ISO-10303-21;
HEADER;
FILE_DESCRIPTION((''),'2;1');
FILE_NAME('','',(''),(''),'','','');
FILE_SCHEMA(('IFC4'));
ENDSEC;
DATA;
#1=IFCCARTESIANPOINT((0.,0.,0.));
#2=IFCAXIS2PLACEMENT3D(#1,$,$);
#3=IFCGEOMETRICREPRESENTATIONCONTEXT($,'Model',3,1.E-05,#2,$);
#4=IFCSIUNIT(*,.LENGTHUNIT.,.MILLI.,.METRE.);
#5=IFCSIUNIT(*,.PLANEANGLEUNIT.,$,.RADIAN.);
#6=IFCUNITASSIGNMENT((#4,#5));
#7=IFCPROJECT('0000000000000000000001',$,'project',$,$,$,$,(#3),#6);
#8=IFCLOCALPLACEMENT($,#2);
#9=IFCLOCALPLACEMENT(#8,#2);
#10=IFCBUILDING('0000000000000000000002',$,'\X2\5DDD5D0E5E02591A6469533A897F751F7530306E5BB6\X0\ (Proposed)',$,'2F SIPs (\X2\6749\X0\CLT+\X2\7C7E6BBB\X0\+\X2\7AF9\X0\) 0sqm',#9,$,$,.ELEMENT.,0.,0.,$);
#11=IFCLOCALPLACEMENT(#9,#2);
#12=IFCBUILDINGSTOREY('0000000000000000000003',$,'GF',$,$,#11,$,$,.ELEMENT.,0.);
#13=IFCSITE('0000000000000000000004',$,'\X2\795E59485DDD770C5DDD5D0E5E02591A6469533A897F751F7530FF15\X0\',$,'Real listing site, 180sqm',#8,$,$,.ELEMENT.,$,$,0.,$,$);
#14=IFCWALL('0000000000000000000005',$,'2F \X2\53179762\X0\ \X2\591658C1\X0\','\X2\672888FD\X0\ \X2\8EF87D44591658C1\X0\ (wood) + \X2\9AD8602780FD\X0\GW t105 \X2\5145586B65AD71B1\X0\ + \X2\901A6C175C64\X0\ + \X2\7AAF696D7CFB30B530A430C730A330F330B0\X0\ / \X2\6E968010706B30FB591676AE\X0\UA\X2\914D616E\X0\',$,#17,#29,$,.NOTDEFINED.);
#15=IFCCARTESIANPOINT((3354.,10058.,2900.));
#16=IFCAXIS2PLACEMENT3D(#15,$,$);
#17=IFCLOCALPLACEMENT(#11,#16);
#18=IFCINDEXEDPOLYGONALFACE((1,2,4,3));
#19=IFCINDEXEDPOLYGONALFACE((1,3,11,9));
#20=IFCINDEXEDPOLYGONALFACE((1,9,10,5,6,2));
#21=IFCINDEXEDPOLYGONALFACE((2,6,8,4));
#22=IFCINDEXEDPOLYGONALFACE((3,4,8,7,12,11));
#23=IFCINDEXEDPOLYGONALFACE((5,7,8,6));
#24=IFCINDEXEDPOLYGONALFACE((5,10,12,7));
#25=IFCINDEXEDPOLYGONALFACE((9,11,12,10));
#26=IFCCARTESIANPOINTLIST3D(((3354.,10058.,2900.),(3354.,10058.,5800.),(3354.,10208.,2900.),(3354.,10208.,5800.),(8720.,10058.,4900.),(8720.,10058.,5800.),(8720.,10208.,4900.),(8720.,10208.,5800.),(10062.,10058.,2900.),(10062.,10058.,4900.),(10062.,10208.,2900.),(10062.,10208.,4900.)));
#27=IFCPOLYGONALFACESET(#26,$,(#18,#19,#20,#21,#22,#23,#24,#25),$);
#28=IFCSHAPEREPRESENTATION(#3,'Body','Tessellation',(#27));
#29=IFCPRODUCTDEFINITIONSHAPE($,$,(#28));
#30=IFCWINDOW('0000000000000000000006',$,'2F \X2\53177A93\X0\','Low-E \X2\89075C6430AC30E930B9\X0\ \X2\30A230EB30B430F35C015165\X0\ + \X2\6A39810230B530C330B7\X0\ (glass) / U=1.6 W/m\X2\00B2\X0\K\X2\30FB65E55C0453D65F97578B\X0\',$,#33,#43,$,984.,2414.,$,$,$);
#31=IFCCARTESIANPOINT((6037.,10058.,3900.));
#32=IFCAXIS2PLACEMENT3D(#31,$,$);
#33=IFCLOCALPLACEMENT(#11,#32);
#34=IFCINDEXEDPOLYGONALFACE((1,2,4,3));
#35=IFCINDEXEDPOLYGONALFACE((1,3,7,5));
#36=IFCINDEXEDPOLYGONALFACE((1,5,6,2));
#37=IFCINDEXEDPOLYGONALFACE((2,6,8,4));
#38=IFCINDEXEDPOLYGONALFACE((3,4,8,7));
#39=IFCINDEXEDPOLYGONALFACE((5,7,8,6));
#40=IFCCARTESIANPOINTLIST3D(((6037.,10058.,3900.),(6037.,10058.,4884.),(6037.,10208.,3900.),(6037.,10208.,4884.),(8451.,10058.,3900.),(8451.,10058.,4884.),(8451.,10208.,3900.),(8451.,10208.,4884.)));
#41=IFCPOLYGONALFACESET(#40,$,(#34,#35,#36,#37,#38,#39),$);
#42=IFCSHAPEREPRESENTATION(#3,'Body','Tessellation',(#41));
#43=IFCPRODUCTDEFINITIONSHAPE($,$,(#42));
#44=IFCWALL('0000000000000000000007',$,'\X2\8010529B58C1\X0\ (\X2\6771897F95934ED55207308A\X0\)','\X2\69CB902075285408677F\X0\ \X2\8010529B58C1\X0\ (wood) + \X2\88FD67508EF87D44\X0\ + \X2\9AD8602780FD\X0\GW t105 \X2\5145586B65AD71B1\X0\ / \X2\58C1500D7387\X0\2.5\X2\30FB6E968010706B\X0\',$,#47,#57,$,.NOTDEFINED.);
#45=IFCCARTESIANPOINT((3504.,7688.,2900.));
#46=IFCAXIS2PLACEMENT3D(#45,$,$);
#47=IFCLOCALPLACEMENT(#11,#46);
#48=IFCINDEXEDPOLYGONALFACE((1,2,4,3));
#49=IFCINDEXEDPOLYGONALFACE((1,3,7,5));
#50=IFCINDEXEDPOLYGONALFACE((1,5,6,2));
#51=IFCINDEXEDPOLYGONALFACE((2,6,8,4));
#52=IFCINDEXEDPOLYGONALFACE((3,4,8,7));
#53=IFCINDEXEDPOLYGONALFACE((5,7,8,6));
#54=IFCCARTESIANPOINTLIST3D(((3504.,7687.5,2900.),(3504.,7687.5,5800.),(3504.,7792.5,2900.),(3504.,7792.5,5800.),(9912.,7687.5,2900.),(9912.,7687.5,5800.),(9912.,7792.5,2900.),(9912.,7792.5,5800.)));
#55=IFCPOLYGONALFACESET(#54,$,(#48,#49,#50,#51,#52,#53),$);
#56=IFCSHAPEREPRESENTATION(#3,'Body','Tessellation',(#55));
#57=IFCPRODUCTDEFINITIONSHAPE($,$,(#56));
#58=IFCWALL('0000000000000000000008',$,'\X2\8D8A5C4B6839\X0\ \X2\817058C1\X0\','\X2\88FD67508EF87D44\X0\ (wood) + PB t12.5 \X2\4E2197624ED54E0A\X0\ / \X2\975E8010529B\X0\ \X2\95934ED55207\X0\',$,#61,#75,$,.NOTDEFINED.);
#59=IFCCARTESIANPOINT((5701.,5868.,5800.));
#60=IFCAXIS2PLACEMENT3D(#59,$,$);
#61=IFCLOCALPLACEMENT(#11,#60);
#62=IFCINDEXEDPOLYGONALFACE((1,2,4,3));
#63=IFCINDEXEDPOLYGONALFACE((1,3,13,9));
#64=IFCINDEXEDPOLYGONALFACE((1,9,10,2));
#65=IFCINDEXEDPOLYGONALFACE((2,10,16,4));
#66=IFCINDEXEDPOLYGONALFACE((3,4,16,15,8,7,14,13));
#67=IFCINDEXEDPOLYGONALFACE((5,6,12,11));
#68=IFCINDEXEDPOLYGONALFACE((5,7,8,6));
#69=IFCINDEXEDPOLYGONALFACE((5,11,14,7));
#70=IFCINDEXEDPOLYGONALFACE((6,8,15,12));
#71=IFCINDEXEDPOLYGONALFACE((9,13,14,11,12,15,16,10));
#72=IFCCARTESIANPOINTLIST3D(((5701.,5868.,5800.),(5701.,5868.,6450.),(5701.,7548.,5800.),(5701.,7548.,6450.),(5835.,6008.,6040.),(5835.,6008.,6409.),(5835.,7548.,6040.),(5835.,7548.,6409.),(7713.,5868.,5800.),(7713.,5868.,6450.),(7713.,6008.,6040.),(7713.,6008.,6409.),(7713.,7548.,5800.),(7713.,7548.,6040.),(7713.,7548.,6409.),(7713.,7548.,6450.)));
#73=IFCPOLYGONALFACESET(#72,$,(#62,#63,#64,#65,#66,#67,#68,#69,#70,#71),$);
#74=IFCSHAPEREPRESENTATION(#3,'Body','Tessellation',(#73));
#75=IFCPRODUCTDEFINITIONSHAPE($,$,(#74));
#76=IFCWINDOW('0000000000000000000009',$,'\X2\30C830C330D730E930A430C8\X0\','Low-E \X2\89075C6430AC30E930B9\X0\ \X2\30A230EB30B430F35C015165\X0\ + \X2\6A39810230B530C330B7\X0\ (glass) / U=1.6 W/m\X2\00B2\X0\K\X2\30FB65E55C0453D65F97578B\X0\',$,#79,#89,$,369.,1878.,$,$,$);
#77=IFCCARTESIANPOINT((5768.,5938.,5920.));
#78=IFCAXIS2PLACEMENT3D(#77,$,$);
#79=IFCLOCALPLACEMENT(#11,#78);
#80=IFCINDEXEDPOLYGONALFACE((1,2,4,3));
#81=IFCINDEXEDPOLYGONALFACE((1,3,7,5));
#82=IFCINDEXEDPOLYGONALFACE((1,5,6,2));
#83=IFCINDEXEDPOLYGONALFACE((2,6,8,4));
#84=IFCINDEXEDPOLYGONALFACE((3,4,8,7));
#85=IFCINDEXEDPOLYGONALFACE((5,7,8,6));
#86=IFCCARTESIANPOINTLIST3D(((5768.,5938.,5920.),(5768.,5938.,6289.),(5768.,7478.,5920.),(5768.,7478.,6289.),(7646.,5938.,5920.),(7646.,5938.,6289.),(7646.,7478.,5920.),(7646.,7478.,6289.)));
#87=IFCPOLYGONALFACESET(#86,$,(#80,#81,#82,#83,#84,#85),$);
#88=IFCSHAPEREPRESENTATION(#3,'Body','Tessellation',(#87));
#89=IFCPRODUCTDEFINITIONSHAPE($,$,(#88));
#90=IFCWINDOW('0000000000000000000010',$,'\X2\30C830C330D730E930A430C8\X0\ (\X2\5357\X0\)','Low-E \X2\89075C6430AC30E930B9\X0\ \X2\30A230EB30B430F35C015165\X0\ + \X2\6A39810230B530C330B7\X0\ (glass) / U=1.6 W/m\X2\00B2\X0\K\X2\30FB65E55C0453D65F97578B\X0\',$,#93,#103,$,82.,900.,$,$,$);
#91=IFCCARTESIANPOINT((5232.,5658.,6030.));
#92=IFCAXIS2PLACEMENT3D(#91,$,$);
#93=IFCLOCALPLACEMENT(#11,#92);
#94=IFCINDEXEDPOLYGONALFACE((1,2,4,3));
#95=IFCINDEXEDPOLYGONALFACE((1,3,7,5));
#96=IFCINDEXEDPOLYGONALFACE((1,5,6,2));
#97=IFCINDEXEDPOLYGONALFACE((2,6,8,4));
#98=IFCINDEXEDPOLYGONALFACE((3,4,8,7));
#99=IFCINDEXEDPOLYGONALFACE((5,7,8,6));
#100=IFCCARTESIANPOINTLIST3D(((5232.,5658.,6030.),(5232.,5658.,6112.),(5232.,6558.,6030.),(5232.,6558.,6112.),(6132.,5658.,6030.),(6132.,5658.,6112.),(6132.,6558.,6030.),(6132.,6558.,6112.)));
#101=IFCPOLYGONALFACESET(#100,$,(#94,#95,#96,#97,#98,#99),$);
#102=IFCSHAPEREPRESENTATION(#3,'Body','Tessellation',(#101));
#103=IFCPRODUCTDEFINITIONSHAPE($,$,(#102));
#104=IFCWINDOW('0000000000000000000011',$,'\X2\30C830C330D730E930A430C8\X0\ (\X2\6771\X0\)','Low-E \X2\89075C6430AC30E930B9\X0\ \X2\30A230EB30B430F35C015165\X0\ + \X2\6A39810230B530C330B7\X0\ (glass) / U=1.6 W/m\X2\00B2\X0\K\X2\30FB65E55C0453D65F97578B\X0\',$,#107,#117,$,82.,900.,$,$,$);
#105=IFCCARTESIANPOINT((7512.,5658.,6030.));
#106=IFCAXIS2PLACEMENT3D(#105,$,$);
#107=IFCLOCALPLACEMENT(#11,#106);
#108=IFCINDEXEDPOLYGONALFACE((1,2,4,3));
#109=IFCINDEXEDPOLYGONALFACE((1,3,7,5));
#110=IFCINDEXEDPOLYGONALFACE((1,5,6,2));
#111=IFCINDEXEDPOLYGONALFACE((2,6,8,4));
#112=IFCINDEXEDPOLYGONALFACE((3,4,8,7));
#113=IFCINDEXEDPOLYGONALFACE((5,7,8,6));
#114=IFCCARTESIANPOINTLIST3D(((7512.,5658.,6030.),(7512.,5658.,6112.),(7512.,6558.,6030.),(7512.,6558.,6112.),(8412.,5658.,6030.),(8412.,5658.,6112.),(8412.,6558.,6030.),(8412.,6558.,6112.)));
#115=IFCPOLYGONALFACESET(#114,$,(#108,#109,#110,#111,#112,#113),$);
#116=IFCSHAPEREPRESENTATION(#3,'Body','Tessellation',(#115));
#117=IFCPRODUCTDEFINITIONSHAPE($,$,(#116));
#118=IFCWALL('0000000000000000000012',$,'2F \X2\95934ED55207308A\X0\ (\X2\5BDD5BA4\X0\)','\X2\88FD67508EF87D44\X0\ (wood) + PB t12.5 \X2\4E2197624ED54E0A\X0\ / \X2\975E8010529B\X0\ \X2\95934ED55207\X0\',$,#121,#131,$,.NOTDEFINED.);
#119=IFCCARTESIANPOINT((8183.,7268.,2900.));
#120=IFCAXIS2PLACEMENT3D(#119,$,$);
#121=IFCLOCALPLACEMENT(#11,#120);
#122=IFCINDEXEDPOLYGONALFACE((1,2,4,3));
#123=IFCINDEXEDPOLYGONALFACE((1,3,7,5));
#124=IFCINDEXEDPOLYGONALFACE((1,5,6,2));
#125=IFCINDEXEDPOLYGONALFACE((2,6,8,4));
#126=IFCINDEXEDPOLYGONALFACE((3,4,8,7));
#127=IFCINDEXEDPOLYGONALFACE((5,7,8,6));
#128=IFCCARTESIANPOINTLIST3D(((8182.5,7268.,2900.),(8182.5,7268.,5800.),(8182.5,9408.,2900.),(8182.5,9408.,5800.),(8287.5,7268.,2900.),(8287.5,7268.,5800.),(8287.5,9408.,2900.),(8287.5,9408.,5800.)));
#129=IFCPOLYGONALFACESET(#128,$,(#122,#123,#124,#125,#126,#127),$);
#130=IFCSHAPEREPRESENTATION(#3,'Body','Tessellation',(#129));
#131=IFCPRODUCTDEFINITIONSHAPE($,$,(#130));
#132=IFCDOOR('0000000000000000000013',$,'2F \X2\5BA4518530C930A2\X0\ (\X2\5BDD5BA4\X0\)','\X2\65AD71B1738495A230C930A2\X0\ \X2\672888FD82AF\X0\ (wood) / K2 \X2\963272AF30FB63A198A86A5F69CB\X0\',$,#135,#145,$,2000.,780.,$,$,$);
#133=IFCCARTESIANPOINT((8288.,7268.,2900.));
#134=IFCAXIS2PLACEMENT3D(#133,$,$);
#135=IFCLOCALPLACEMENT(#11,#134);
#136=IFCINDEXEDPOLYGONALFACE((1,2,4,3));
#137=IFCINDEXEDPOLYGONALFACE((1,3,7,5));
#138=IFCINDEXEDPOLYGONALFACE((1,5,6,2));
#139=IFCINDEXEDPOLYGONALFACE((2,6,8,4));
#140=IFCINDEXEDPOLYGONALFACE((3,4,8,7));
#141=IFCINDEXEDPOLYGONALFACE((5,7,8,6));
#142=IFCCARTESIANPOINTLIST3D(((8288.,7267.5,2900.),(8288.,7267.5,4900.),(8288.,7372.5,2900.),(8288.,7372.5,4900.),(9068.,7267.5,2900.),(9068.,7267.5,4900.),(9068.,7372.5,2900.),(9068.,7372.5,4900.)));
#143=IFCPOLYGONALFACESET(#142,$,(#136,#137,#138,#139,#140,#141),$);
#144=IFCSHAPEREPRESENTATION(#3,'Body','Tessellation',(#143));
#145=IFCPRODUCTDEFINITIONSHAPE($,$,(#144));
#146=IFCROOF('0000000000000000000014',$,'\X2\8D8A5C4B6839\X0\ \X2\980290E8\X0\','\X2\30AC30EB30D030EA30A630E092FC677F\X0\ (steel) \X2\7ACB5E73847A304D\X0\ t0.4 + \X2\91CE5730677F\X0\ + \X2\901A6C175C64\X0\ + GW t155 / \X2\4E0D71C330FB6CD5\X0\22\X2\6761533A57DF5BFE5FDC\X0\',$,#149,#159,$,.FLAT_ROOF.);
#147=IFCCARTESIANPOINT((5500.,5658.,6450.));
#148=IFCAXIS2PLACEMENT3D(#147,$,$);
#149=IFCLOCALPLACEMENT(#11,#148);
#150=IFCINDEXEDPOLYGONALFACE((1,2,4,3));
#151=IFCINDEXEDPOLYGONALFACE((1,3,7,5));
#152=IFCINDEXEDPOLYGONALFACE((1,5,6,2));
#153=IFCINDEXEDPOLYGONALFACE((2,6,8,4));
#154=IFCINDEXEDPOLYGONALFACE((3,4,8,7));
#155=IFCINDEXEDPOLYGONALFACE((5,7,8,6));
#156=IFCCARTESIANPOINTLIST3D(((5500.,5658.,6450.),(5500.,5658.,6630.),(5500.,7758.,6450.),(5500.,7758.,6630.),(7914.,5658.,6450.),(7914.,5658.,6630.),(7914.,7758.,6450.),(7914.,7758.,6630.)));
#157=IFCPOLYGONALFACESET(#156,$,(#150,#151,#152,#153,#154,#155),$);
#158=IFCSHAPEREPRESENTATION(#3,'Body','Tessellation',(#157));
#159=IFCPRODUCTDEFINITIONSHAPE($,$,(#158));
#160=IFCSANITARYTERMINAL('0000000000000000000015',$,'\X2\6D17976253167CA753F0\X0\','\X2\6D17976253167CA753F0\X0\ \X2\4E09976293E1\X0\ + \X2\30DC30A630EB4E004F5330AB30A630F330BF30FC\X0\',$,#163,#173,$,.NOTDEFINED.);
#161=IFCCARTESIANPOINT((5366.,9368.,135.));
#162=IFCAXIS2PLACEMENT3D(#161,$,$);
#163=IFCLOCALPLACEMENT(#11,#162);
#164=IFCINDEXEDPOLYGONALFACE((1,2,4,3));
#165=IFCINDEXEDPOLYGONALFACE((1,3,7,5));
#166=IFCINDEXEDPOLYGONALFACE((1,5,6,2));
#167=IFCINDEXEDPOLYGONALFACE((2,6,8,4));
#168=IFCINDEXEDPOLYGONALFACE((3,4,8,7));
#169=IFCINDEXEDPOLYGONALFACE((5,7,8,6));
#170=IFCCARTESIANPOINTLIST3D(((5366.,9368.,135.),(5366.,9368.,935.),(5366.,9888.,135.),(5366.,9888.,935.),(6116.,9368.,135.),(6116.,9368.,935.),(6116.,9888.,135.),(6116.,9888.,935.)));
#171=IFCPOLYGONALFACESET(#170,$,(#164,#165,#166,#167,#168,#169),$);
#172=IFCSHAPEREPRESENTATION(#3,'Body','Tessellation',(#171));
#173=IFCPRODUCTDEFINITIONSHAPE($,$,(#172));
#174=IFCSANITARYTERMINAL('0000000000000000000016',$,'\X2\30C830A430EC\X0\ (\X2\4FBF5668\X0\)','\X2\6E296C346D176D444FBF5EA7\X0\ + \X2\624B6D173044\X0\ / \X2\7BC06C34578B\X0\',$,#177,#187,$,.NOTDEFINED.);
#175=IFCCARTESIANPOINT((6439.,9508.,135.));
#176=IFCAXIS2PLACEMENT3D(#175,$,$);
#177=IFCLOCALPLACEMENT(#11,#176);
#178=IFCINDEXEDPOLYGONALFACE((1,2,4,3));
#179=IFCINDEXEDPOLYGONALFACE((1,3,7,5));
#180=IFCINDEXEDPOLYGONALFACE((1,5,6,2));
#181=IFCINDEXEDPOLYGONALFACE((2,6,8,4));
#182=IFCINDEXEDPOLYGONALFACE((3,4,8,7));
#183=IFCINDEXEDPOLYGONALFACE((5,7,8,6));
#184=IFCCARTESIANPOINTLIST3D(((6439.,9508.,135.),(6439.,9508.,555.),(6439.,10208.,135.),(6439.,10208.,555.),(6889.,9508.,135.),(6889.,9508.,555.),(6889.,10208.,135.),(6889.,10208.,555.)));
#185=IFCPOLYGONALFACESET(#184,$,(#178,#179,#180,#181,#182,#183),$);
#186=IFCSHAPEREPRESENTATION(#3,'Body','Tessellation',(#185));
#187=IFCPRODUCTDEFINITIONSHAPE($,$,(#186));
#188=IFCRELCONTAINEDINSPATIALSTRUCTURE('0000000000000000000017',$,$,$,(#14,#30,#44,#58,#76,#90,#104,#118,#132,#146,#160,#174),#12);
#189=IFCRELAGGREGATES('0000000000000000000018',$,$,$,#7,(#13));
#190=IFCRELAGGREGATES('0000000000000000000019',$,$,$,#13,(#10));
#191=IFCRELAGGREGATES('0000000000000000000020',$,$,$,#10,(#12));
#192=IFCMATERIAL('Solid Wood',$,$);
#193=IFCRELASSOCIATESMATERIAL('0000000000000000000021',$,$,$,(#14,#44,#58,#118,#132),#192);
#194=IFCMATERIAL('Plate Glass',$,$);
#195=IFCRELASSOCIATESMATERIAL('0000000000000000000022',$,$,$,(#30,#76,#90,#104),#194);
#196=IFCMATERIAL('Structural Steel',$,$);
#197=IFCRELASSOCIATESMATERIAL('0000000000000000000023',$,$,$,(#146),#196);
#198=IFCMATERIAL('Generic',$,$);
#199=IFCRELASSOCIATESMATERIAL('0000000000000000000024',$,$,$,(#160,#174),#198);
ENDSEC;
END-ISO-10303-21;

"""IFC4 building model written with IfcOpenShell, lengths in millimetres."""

from ifc_helpers import new_model, si_unit, frame, frame_2d, origin, place, context, project, spatial, rectangle, extrude, material, element, fill, save


model = new_model("IFC4")

# Units and contexts
model_context = context("Model", 3, precision=1e-05, world=origin())
ifc_project = project(units=[si_unit("LENGTHUNIT", "METRE", prefix="MILLI"), si_unit("PLANEANGLEUNIT", "RADIAN")], contexts=[model_context])

# Site, building, storey
site_placement = place(None, origin())
site = spatial("IfcSite", under=ifc_project, at=site_placement, Name="神奈川県川崎市多摩区西生田５", ObjectType="Real listing site, 180sqm", CompositionType="ELEMENT", RefElevation=0.0)
building_placement = place(site_placement, origin())
building = spatial("IfcBuilding", under=site, at=building_placement, Name="川崎市多摩区西生田の家 (Proposed)", ObjectType="2F SIPs (杉CLT+籾殻+竹) 0sqm", CompositionType="ELEMENT", ElevationOfRefHeight=0.0, ElevationOfTerrain=0.0)
storey_placement = place(building_placement, origin())
storey = spatial("IfcBuildingStorey", under=building, at=storey_placement, Name="GF", CompositionType="ELEMENT", Elevation=0.0)

# Wall, opening, window
ifc_material_1 = material(Name="Solid Wood")
wall_1_placement = place(storey_placement, frame((3354.0, 10058.0, 2900.0)))
wall_1 = element("IfcWall", 1, at=wall_1_placement, inside=storey, material=ifc_material_1, Name="2F 北面 外壁", Description="木製 軸組外壁 (wood) + 高性能GW t105 充填断熱 + 通気層 + 窯業系サイディング / 準耐火・外皮UA配慮", PredefinedType="NOTDEFINED", context=model_context, shape_type="SweptSolid", body=[
    extrude(rectangle(XDim=6708.0, YDim=150.0, at=frame_2d((3354.0, 75.0))), frame((3354.0, 10058.0, 2900.0)), (0.0, 0.0, 1.0), 2900.0),
])
opening_1_placement = place(storey_placement, frame((6037.0, 10058.0, 3900.0)))
opening_1 = element("IfcOpeningElement", 2, at=opening_1_placement, cuts=wall_1, PredefinedType="NOTDEFINED", context=model_context, shape_type="SweptSolid", body=[
    extrude(rectangle(XDim=2414.0, YDim=150.0, at=frame_2d((1207.0, 75.0))), frame((6037.0, 10058.0, 3900.0)), (0.0, 0.0, 1.0), 984.0),
])
ifc_material_2 = material(Name="Plate Glass")
window_1_placement = place(storey_placement, frame((6037.0, 10058.0, 3900.0)))
window_1 = element("IfcWindow", 3, at=window_1_placement, inside=storey, material=ifc_material_2, Name="2F 北窓", Description="Low-E 複層ガラス アルゴン封入 + 樹脂サッシ (glass) / U=1.6 W/m²K・日射取得型", OverallHeight=984.0, OverallWidth=2414.0, context=model_context, shape_type="SweptSolid", body=[
    extrude(rectangle(XDim=2414.0, YDim=150.0, at=frame_2d((1207.0, 75.0))), frame((6037.0, 10058.0, 3900.0)), (0.0, 0.0, 1.0), 984.0),
])
fill(opening_1, window_1)

# Wall
wall_2_placement = place(storey_placement, frame((3504.0, 7688.0, 2900.0)))
element("IfcWall", 4, at=wall_2_placement, inside=storey, material=ifc_material_1, Name="耐力壁 (東西間仕切り)", Description="構造用合板 耐力壁 (wood) + 製材軸組 + 高性能GW t105 充填断熱 / 壁倍率2.5・準耐火", PredefinedType="NOTDEFINED", context=model_context, shape_type="SweptSolid", body=[
    extrude(rectangle(XDim=6408.0, YDim=105.0, at=frame_2d((3204.0, 52.0))), frame((3504.0, 7688.0, 2900.0)), (0.0, 0.0, 1.0), 2900.0),
])

# Wall, openings, windows
wall_3_placement = place(storey_placement, frame((5701.0, 5868.0, 5800.0)))
wall_3 = element("IfcWall", 5, at=wall_3_placement, inside=storey, material=ifc_material_1, Name="越屋根 腰壁", Description="製材軸組 (wood) + PB t12.5 両面仕上 / 非耐力 間仕切", PredefinedType="NOTDEFINED", context=model_context, shape_type="SweptSolid", body=[
    extrude(rectangle(XDim=2012.0, YDim=1680.0, at=frame_2d((1006.0, 840.0))), frame((5701.0, 5868.0, 5800.0)), (0.0, 0.0, 1.0), 650.0),
])
opening_2_placement = place(storey_placement, frame((5768.0, 5938.0, 5920.0)))
opening_2 = element("IfcOpeningElement", 6, at=opening_2_placement, cuts=wall_3, PredefinedType="NOTDEFINED", context=model_context, shape_type="SweptSolid", body=[
    extrude(rectangle(XDim=1878.0, YDim=1540.0, at=frame_2d((939.0, 770.0))), frame((5768.0, 5938.0, 5920.0)), (0.0, 0.0, 1.0), 369.0),
])
opening_3_placement = place(storey_placement, frame((5232.0, 5658.0, 6030.0)))
opening_3 = element("IfcOpeningElement", 7, at=opening_3_placement, cuts=wall_3, PredefinedType="NOTDEFINED", context=model_context, shape_type="SweptSolid", body=[
    extrude(rectangle(XDim=900.0, YDim=900.0, at=frame_2d((450.0, 450.0))), frame((5232.0, 5658.0, 6030.0)), (0.0, 0.0, 1.0), 82.0),
])
opening_4_placement = place(storey_placement, frame((7512.0, 5658.0, 6030.0)))
opening_4 = element("IfcOpeningElement", 8, at=opening_4_placement, cuts=wall_3, PredefinedType="NOTDEFINED", context=model_context, shape_type="SweptSolid", body=[
    extrude(rectangle(XDim=900.0, YDim=900.0, at=frame_2d((450.0, 450.0))), frame((7512.0, 5658.0, 6030.0)), (0.0, 0.0, 1.0), 82.0),
])
window_2_placement = place(storey_placement, frame((5768.0, 5938.0, 5920.0)))
window_2 = element("IfcWindow", 9, at=window_2_placement, inside=storey, material=ifc_material_2, Name="トップライト", Description="Low-E 複層ガラス アルゴン封入 + 樹脂サッシ (glass) / U=1.6 W/m²K・日射取得型", OverallHeight=369.0, OverallWidth=1878.0, context=model_context, shape_type="SweptSolid", body=[
    extrude(rectangle(XDim=1878.0, YDim=1540.0, at=frame_2d((939.0, 770.0))), frame((5768.0, 5938.0, 5920.0)), (0.0, 0.0, 1.0), 369.0),
])
fill(opening_2, window_2)
window_3_placement = place(storey_placement, frame((5232.0, 5658.0, 6030.0)))
window_3 = element("IfcWindow", 10, at=window_3_placement, inside=storey, material=ifc_material_2, Name="トップライト (南)", Description="Low-E 複層ガラス アルゴン封入 + 樹脂サッシ (glass) / U=1.6 W/m²K・日射取得型", OverallHeight=82.0, OverallWidth=900.0, context=model_context, shape_type="SweptSolid", body=[
    extrude(rectangle(XDim=900.0, YDim=900.0, at=frame_2d((450.0, 450.0))), frame((5232.0, 5658.0, 6030.0)), (0.0, 0.0, 1.0), 82.0),
])
fill(opening_3, window_3)
window_4_placement = place(storey_placement, frame((7512.0, 5658.0, 6030.0)))
window_4 = element("IfcWindow", 11, at=window_4_placement, inside=storey, material=ifc_material_2, Name="トップライト (東)", Description="Low-E 複層ガラス アルゴン封入 + 樹脂サッシ (glass) / U=1.6 W/m²K・日射取得型", OverallHeight=82.0, OverallWidth=900.0, context=model_context, shape_type="SweptSolid", body=[
    extrude(rectangle(XDim=900.0, YDim=900.0, at=frame_2d((450.0, 450.0))), frame((7512.0, 5658.0, 6030.0)), (0.0, 0.0, 1.0), 82.0),
])
fill(opening_4, window_4)

# Wall
wall_4_placement = place(storey_placement, frame((8183.0, 7268.0, 2900.0)))
element("IfcWall", 12, at=wall_4_placement, inside=storey, material=ifc_material_1, Name="2F 間仕切り (寝室)", Description="製材軸組 (wood) + PB t12.5 両面仕上 / 非耐力 間仕切", PredefinedType="NOTDEFINED", context=model_context, shape_type="SweptSolid", body=[
    extrude(rectangle(XDim=105.0, YDim=2140.0, at=frame_2d((52.0, 1070.0))), frame((8183.0, 7268.0, 2900.0)), (0.0, 0.0, 1.0), 2900.0),
])

# Door
door_placement = place(storey_placement, frame((8288.0, 7268.0, 2900.0)))
element("IfcDoor", 13, at=door_placement, inside=storey, material=ifc_material_1, Name="2F 室内ドア (寝室)", Description="断熱玄関ドア 木製芯 (wood) / K2 防犯・採風機構", OverallHeight=2000.0, OverallWidth=780.0, context=model_context, shape_type="SweptSolid", body=[
    extrude(rectangle(XDim=780.0, YDim=105.0, at=frame_2d((390.0, 52.0))), frame((8288.0, 7268.0, 2900.0)), (0.0, 0.0, 1.0), 2000.0),
])

# Roof
ifc_material_3 = material(Name="Structural Steel")
roof_placement = place(storey_placement, frame((5500.0, 5658.0, 6450.0)))
element("IfcRoof", 14, at=roof_placement, inside=storey, material=ifc_material_3, Name="越屋根 頂部", Description="ガルバリウム鋼板 (steel) 立平葺き t0.4 + 野地板 + 通気層 + GW t155 / 不燃・法22条区域対応", PredefinedType="FLAT_ROOF", context=model_context, shape_type="SweptSolid", body=[
    extrude(rectangle(XDim=2414.0, YDim=2100.0, at=frame_2d((1207.0, 1050.0))), frame((5500.0, 5658.0, 6450.0)), (0.0, 0.0, 1.0), 180.0),
])

# Sanitary terminals
ifc_material_4 = material(Name="Generic")
sanitary_terminal_1_placement = place(storey_placement, frame((5366.0, 9368.0, 135.0)))
element("IfcSanitaryTerminal", 15, at=sanitary_terminal_1_placement, inside=storey, material=ifc_material_4, Name="洗面化粧台", Description="洗面化粧台 三面鏡 + ボウル一体カウンター", PredefinedType="NOTDEFINED", context=model_context, shape_type="SweptSolid", body=[
    extrude(rectangle(XDim=750.0, YDim=520.0, at=frame_2d((375.0, 260.0))), frame((5366.0, 9368.0, 135.0)), (0.0, 0.0, 1.0), 800.0),
])
sanitary_terminal_2_placement = place(storey_placement, frame((6439.0, 9508.0, 135.0)))
element("IfcSanitaryTerminal", 16, at=sanitary_terminal_2_placement, inside=storey, material=ifc_material_4, Name="トイレ (便器)", Description="温水洗浄便座 + 手洗い / 節水型", PredefinedType="NOTDEFINED", context=model_context, shape_type="SweptSolid", body=[
    extrude(rectangle(XDim=450.0, YDim=700.0, at=frame_2d((225.0, 350.0))), frame((6439.0, 9508.0, 135.0)), (0.0, 0.0, 1.0), 420.0),
])

save(model, "model.ifc")
